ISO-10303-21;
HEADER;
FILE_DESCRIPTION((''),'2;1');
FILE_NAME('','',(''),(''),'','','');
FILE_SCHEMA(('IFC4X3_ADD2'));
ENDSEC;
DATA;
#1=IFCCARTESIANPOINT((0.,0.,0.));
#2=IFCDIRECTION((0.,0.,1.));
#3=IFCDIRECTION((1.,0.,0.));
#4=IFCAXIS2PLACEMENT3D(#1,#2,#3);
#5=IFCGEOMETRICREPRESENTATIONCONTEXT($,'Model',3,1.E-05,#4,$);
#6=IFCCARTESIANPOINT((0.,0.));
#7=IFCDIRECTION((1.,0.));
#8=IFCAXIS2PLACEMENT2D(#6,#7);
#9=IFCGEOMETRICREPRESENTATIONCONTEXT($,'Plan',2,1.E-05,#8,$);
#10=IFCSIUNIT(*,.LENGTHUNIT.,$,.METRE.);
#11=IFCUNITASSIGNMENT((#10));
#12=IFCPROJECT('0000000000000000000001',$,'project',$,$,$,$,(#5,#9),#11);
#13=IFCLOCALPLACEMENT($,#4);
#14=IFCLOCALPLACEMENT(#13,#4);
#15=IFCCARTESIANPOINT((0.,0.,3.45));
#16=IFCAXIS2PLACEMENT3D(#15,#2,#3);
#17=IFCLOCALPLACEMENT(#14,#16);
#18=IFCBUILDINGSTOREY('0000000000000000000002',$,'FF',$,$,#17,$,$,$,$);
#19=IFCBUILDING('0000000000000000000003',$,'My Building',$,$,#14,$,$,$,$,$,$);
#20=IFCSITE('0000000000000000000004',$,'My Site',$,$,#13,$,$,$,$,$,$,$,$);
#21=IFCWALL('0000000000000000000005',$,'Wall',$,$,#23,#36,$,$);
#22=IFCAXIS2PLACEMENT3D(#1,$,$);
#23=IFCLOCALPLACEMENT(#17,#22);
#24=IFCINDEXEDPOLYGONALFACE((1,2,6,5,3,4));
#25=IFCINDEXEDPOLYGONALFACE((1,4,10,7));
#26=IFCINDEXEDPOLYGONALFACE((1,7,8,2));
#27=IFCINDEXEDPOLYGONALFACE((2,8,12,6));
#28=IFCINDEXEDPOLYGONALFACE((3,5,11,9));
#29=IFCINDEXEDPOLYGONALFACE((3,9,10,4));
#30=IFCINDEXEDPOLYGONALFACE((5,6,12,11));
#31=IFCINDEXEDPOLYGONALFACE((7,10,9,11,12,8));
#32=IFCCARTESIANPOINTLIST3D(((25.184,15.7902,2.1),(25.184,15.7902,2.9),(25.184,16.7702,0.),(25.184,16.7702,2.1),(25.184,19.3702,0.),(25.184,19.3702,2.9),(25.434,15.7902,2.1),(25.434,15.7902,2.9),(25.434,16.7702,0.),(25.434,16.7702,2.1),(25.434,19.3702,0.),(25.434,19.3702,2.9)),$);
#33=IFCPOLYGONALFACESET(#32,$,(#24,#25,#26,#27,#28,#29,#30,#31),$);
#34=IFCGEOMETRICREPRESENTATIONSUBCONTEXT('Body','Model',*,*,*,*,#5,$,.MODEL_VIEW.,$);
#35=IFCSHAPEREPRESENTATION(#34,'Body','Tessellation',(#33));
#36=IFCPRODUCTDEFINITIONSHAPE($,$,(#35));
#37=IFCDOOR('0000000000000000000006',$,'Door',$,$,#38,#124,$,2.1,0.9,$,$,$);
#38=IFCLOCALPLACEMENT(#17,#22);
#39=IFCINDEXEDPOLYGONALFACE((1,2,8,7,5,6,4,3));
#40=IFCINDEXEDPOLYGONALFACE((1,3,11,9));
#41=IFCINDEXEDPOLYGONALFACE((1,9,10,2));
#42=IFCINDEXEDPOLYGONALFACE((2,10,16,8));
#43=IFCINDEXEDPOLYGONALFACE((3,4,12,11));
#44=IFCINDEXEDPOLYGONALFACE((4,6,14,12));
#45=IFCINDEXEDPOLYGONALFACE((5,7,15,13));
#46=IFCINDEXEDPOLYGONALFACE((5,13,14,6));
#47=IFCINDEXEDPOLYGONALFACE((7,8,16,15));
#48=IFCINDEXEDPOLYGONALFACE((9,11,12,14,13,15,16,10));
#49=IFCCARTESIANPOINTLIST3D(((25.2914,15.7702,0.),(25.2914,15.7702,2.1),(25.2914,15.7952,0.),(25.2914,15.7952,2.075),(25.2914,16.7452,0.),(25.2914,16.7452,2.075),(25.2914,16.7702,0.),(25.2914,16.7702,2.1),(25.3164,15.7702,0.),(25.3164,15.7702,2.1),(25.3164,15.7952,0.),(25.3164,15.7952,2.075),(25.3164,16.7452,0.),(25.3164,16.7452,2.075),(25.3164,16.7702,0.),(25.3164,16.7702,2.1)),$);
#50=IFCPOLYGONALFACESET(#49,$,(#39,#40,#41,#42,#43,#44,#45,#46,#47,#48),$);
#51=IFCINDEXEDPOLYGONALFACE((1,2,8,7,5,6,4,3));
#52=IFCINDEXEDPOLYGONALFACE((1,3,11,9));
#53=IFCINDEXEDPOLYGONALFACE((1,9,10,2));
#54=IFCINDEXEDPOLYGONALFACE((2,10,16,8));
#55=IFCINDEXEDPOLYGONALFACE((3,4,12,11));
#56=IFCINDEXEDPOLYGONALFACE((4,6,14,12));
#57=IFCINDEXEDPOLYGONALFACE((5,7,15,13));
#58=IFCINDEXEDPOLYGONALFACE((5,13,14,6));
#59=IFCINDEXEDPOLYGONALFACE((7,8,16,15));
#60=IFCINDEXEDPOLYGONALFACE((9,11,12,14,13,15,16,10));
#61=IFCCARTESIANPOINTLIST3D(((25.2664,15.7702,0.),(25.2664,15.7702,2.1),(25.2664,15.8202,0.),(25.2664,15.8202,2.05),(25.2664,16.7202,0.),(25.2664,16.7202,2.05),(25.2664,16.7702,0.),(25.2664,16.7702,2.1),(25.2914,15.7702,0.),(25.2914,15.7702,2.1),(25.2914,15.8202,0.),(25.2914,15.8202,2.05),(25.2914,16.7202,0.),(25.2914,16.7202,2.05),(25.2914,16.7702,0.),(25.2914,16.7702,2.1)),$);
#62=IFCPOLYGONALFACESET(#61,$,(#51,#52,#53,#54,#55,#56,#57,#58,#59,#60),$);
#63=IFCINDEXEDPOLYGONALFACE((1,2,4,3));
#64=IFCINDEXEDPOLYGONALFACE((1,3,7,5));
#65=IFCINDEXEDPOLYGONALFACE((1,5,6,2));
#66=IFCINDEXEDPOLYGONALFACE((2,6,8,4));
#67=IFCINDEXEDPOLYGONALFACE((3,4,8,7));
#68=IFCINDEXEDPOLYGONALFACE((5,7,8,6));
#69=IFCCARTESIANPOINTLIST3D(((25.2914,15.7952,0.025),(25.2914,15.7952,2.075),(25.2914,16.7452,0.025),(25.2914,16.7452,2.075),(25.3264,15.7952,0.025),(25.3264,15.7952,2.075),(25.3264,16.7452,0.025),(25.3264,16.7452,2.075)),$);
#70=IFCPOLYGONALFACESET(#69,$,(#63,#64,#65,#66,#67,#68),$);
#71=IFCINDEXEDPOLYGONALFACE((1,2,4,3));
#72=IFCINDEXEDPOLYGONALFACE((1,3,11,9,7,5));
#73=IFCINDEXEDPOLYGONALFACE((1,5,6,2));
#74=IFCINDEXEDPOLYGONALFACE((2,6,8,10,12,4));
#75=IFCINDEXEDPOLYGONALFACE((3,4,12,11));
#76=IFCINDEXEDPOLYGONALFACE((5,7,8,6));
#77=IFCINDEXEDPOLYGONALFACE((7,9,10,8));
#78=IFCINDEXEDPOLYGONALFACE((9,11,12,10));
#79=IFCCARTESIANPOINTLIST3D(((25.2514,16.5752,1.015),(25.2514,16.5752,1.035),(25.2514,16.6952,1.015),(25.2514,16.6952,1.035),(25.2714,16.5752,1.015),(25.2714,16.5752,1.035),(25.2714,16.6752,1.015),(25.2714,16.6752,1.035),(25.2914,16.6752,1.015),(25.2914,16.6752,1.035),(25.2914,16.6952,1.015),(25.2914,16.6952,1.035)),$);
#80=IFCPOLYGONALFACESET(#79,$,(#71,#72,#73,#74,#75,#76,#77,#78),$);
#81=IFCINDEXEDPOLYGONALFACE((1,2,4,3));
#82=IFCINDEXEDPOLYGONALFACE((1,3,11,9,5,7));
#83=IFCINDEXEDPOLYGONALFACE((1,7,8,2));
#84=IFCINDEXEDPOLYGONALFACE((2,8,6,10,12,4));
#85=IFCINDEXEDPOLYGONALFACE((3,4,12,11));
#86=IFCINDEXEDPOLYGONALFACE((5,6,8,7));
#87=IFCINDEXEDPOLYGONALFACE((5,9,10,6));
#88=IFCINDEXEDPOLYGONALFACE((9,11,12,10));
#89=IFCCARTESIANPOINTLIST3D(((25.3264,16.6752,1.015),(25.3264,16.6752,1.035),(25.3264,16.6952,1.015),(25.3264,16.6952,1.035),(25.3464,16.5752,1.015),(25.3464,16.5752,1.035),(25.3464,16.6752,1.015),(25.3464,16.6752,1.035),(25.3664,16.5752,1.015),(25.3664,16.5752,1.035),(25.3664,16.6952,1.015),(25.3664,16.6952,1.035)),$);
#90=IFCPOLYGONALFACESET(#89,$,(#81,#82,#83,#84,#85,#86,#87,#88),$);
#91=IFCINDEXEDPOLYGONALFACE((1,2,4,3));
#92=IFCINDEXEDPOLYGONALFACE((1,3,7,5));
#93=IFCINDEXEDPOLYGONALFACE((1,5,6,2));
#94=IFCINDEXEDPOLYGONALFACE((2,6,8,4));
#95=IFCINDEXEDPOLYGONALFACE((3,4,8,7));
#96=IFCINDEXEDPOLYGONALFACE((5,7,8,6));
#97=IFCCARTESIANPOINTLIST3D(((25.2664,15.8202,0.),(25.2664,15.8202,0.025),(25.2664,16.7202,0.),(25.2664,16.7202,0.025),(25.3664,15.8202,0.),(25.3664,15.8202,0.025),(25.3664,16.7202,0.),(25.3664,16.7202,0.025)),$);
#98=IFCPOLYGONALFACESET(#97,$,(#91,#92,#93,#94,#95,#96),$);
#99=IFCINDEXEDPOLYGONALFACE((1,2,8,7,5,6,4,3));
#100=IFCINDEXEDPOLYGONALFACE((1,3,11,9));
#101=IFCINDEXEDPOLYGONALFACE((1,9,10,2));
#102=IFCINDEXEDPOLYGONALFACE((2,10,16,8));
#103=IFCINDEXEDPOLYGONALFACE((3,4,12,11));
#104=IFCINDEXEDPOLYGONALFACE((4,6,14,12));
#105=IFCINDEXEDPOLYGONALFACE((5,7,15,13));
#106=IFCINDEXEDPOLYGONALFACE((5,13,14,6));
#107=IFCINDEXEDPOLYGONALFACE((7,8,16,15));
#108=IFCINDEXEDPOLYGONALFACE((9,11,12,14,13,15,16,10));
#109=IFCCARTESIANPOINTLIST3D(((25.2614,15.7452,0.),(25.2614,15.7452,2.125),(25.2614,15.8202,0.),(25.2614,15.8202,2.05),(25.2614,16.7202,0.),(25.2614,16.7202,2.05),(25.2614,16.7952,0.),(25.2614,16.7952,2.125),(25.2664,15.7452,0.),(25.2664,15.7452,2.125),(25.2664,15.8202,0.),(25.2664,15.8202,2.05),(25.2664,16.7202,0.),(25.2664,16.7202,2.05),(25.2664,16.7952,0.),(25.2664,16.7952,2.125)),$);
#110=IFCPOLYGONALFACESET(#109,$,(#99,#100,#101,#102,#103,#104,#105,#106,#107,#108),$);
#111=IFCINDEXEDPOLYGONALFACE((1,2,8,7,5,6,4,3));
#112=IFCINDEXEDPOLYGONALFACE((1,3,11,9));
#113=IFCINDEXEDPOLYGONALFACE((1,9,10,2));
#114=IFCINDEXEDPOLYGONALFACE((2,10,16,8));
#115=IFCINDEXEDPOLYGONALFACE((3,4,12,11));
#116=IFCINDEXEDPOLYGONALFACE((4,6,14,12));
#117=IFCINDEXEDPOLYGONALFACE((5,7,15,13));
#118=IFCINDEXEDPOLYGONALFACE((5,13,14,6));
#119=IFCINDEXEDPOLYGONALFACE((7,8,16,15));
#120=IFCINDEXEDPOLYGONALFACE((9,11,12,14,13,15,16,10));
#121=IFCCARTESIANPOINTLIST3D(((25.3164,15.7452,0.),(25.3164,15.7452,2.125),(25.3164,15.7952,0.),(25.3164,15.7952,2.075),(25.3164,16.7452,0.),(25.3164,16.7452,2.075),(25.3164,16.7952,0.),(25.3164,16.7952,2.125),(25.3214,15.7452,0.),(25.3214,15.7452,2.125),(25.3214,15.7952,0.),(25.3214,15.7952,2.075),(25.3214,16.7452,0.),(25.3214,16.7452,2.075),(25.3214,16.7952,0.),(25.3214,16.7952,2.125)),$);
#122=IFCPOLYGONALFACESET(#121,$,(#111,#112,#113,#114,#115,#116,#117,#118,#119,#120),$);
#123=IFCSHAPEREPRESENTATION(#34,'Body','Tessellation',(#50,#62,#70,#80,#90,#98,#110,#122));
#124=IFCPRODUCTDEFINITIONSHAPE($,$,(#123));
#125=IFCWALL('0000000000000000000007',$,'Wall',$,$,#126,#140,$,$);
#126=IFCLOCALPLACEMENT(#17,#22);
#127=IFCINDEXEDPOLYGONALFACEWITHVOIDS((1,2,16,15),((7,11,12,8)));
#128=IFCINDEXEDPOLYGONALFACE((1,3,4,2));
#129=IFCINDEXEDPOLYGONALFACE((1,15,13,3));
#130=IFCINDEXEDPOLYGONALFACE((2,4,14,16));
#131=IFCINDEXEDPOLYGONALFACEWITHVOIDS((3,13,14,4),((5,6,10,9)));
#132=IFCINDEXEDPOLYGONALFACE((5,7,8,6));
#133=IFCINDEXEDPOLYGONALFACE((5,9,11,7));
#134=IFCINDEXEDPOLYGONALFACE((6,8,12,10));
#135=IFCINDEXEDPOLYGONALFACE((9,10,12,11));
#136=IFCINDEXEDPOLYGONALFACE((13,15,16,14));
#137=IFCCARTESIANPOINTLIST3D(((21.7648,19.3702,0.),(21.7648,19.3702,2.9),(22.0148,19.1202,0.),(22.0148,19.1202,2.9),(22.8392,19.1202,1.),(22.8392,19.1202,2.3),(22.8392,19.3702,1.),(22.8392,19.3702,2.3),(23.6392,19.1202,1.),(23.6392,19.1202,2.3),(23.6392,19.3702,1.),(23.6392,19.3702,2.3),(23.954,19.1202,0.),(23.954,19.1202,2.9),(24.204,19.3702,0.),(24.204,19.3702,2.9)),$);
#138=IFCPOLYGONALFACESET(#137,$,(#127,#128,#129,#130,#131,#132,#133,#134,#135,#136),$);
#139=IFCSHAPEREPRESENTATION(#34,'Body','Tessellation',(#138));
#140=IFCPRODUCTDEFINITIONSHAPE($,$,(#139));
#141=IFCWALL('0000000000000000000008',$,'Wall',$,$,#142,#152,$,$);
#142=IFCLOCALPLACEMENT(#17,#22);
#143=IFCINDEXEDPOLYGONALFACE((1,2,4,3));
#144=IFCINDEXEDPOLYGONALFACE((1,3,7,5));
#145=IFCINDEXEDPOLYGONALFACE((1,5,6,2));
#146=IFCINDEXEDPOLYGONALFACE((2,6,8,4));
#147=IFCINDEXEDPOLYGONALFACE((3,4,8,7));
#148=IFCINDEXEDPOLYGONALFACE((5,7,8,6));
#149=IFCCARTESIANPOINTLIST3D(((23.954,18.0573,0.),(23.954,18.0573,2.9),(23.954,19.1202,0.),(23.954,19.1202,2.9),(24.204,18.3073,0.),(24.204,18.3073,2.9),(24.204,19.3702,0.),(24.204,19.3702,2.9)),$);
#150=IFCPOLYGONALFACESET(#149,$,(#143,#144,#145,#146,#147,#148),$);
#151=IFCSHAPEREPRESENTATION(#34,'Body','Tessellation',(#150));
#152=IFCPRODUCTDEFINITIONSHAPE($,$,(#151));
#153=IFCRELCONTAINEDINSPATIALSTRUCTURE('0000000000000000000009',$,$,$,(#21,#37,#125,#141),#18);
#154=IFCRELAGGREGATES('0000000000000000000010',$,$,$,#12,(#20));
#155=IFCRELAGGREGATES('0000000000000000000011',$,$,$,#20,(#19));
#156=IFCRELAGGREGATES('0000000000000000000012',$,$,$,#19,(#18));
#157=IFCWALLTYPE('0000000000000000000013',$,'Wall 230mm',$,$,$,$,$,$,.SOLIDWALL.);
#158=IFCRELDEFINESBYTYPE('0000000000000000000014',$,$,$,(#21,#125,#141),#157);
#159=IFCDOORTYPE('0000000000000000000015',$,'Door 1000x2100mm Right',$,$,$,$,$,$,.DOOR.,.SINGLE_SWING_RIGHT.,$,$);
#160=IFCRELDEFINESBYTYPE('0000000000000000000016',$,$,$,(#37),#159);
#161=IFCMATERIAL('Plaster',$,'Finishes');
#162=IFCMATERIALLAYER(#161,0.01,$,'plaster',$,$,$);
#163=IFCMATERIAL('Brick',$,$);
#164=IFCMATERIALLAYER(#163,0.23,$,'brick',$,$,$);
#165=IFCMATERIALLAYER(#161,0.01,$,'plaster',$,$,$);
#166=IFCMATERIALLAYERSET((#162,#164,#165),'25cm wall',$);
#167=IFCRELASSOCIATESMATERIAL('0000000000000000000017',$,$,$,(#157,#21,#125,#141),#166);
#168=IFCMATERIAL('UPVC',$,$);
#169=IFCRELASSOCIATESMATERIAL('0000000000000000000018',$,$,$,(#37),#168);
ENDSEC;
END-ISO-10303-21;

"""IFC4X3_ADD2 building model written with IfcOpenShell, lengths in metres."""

from ifc_helpers import new_model, entity, si_unit, frame, origin_with_axes, origin_2d_with_axis, place, context, subcontext, project, spatial, line, indexed_curve, outline, extrude, shape, source, transform, mapped, material, layer, layer_set, layer_usage, type_object, type_shapes, element, fill, save


model = new_model("IFC4X3_ADD2")

# Units and contexts
model_context = context("Model", 3, precision=1e-05, world=origin_with_axes())
plan_context = context("Plan", 2, precision=1e-05, world=origin_2d_with_axis())
body_context_1 = subcontext(model_context, "Body", "Model", "MODEL_VIEW")
body_context_2 = subcontext(plan_context, "Body", "Plan", "PLAN_VIEW")
ifc_project = project(units=[si_unit("LENGTHUNIT", "METRE")], contexts=[model_context, plan_context])

# Site, building, storey
site_placement = place(None, origin_with_axes())
site = spatial("IfcSite", under=ifc_project, at=site_placement, Name="My Site")
building_placement = place(site_placement, origin_with_axes())
building = spatial("IfcBuilding", under=site, at=building_placement, Name="My Building")
storey_placement = place(building_placement, frame((0.0, 0.0, 3.45), z_axis=(0.0, 0.0, 1.0), x_axis=(1.0, 0.0, 0.0)))
storey = spatial("IfcBuildingStorey", under=building, at=storey_placement, Name="FF")

# Shared definitions
ifc_material_1 = material(Name="UPVC")

# Shared definitions
ifc_material_2 = material(Name="Plaster", Category="Finishes")
ifc_layer_1 = layer(ifc_material_2, 0.01, Name="plaster")
ifc_material_3 = material(Name="Brick")
ifc_layer_2 = layer(ifc_material_3, 0.23, Name="brick")
ifc_layer_3 = layer(ifc_material_2, 0.01, Name="plaster")
ifc_layer_set = layer_set([ifc_layer_1, ifc_layer_2, ifc_layer_3], Name="25cm wall")
wall_type = type_object("IfcWallType", Name="Wall 230mm", PredefinedType="SOLIDWALL", material=ifc_layer_set)
shared_shape_1 = source(origin_with_axes(), body_context_1, "Body", "SweptSolid", [
    extrude(outline(indexed_curve([(0.0, 0.0), (0.8, 0.0), (0.8, 1.3), (0.0, 1.3)], segments=[line(1, 2, 3, 4, 1)])), frame((-0.4, -0.6, 0.0), z_axis=(0.0, -1.0, 0.0), x_axis=(1.0, 0.0, 0.0)), (0.0, 0.0, -1.0), 1.2),
])

# Wall, opening, door
ifc_layer_usage_1 = layer_usage(ifc_layer_set, "AXIS2", "POSITIVE", 0.0)
wall_1_placement = place(storey_placement, frame((25.434, 15.5402, 0.0), z_axis=(0.0, 0.0, 1.0), x_axis=(0.000001, 1.0, 0.0)))
wall_1 = element("IfcWall", 1, at=wall_1_placement, inside=storey, type_object=wall_type, material=ifc_layer_usage_1, Name="Wall", context=body_context_1, shape_type="SweptSolid", body=[
    extrude(outline(indexed_curve([(0.25, 0.0), (0.25, 0.25), (3.83, 0.25), (3.83, 0.0)], segments=[line(1, 2, 3, 4, 1)])), origin_with_axes(), (0.0, 0.0, 1.0), 2.9),
])
shared_shape_2 = source(origin_with_axes(), body_context_1, "Body", "SweptSolid", [
    extrude(outline(indexed_curve([(0.0, 0.0), (1.0, 0.0), (1.0, 2.1), (0.0, 2.1)], segments=[line(1, 2, 3, 4, 1)])), frame((0.0, -0.6, 0.0), z_axis=(0.0, -1.0, 0.0), x_axis=(1.0, 0.0, 0.0)), (0.0, 0.0, -1.0), 1.2),
])
opening_1_placement = place(wall_1_placement, frame((1.23, 0.1676, 0.0), z_axis=(0.0, 0.0, 1.0), x_axis=(-1.0, 0.0, 0.0)))
opening_1 = element("IfcOpeningElement", 2, at=opening_1_placement, cuts=wall_1, PredefinedType="OPENING", context=body_context_1, shape_type="MappedRepresentation", body=[
    mapped(shared_shape_2, transform((0.0, 0.0, 0.0), x_axis=(1.0, 0.0, 0.0), y_axis=(0.0, 1.0, 0.0), z_axis=(0.0, 0.0, 1.0), scale=1.0)),
])
door_type_1 = type_object("IfcDoorType", Name="Door 1000x2100mm Right", OperationType="SINGLE_SWING_RIGHT", PredefinedType="DOOR")
shared_shape_3 = source(origin_with_axes(), body_context_1, "Body", "SweptSolid", [
    extrude(outline(indexed_curve([(0.0, 0.0), (0.0, 2.1), (1.0, 2.1), (1.0, 0.0), (0.975, 0.0), (0.975, 2.075), (0.025, 2.075), (0.025, 0.0)], segments=[line(1, 2, 3, 4, 5, 6, 7, 8, 1)])), frame((0.0, 0.025, 0.0), z_axis=(0.0, -1.0, 0.0), x_axis=(1.0, 0.0, 0.0)), (0.0, 0.0, -1.0), 0.025),
    extrude(outline(indexed_curve([(0.0, 0.0), (0.0, 2.1), (1.0, 2.1), (1.0, 0.0), (0.95, 0.0), (0.95, 2.05), (0.05, 2.05), (0.05, 0.0)], segments=[line(1, 2, 3, 4, 5, 6, 7, 8, 1)])), frame((0.0, 0.0, 0.0), z_axis=(0.0, -1.0, 0.0), x_axis=(1.0, 0.0, 0.0)), (0.0, 0.0, -1.0), 0.025),
    extrude(outline(indexed_curve([(0.0, 0.0), (0.95, 0.0), (0.95, 0.035), (0.0, 0.035)], segments=[line(1, 2, 3, 4, 1)])), frame((0.025, 0.025, 0.025), z_axis=(0.0, 0.0, 1.0), x_axis=(1.0, 0.0, 0.0)), (0.0, 0.0, 1.0), 2.05),
    extrude(outline(indexed_curve([(0.0, 0.0), (0.0, -0.04), (0.12, -0.04), (0.12, -0.02), (0.02, -0.02), (0.02, 0.0)], segments=[line(1, 2, 3, 4, 5, 6, 1)])), frame((0.075, 0.025, 1.015), z_axis=(0.0, 0.0, 1.0), x_axis=(1.0, 0.0, 0.0)), (0.0, 0.0, 1.0), 0.02),
    extrude(outline(indexed_curve([(0.0, 0.0), (0.0, 0.04), (0.12, 0.04), (0.12, 0.02), (0.02, 0.02), (0.02, 0.0)], segments=[line(1, 2, 3, 4, 5, 6, 1)])), frame((0.075, 0.06, 1.015), z_axis=(0.0, 0.0, 1.0), x_axis=(1.0, 0.0, 0.0)), (0.0, 0.0, 1.0), 0.02),
    extrude(outline(indexed_curve([(0.0, 0.0), (0.9, 0.0), (0.9, 0.1), (0.0, 0.1)], segments=[line(1, 2, 3, 4, 1)])), frame((0.05, 0.0, 0.0), z_axis=(0.0, 0.0, 1.0), x_axis=(1.0, 0.0, 0.0)), (0.0, 0.0, 1.0), 0.025),
    extrude(outline(indexed_curve([(0.0, 0.0), (0.0, 2.125), (1.05, 2.125), (1.05, 0.0), (0.975, 0.0), (0.975, 2.05), (0.075, 2.05), (0.075, 0.0)], segments=[line(1, 2, 3, 4, 5, 6, 7, 8, 1)])), frame((-0.025, -0.005, 0.0), z_axis=(0.0, -1.0, 0.0), x_axis=(1.0, 0.0, 0.0)), (0.0, 0.0, -1.0), 0.005),
    extrude(outline(indexed_curve([(0.0, 0.0), (0.0, 2.125), (1.05, 2.125), (1.05, 0.0), (1.0, 0.0), (1.0, 2.075), (0.05, 2.075), (0.05, 0.0)], segments=[line(1, 2, 3, 4, 5, 6, 7, 8, 1)])), frame((-0.025, 0.05, 0.0), z_axis=(0.0, -1.0, 0.0), x_axis=(1.0, 0.0, 0.0)), (0.0, 0.0, -1.0), 0.005),
])
shared_shape_4 = source(origin_with_axes(), body_context_2, "Body", "Curve2D", [
    entity("IfcIndexedPolyCurve", entity("IfcCartesianPointList2D", [[0.0, 0.0], [0.0, 0.05], [0.025, 0.05], [0.025, 0.025], [0.05, 0.025], [0.05, 0.0]]), [entity("IfcLineIndex", [1, 2, 3, 4, 5, 6, 1])]),
    entity("IfcIndexedPolyCurve", entity("IfcCartesianPointList2D", [[1.0, 0.0], [1.0, 0.05], [0.975, 0.05], [0.975, 0.025], [0.95, 0.025], [0.95, 0.0]]), [entity("IfcLineIndex", [1, 2, 3, 4, 5, 6, 1])]),
    entity("IfcTrimmedCurve", entity("IfcEllipse", entity("IfcAxis2Placement2D", entity("IfcCartesianPoint", [0.94, 0.05]), entity("IfcDirection", [1.0, 0.0])), 0.915, 0.95), [entity("IfcCartesianPoint", [0.94, 1.0])], [entity("IfcCartesianPoint", [0.025, 0.05])], True, "CARTESIAN"),
    entity("IfcIndexedPolyCurve", entity("IfcCartesianPointList2D", [[0.975, 0.05], [0.94, 0.05], [0.94, 1.0], [0.975, 1.0]]), [entity("IfcLineIndex", [1, 2, 3, 4, 1])]),
])
type_shapes(door_type_1, [shared_shape_3, shared_shape_4])
door_1_placement = place(opening_1_placement, origin_with_axes())
door_1 = element("IfcDoor", 3, at=door_1_placement, inside=storey, type_object=door_type_1, material=ifc_material_1, Name="Door", OverallHeight=2.1, OverallWidth=0.9, shapes=[
    shape(body_context_1, "Body", "MappedRepresentation", [mapped(shared_shape_3, transform((0.0, 0.0, 0.0), x_axis=(1.0, 0.0, 0.0), y_axis=(0.0, 1.0, 0.0), z_axis=(0.0, 0.0, 1.0), scale=1.0))]),
    shape(body_context_2, "Body", "MappedRepresentation", [mapped(shared_shape_4, transform((0.0, 0.0, 0.0), x_axis=(1.0, 0.0, 0.0), y_axis=(0.0, 1.0, 0.0), z_axis=(0.0, 0.0, 1.0), scale=1.0))]),
])
fill(opening_1, door_1)

# Wall, opening
ifc_layer_usage_2 = layer_usage(ifc_layer_set, "AXIS2", "POSITIVE", 0.0)
wall_2_placement = place(storey_placement, frame((24.204, 19.3702, 0.0), z_axis=(0.0, 0.0, 1.0), x_axis=(-1.0, 0.0, 0.0)))
wall_2 = element("IfcWall", 4, at=wall_2_placement, inside=storey, type_object=wall_type, material=ifc_layer_usage_2, Name="Wall", context=body_context_1, shape_type="SweptSolid", body=[
    extrude(outline(indexed_curve([(0.0, 0.0), (0.25, 0.25), (2.1892, 0.25), (2.4392, 0.0)], segments=[line(1, 2, 3, 4, 1)])), origin_with_axes(), (0.0, 0.0, 1.0), 2.9),
])
opening_2_placement = place(wall_2_placement, frame((0.9648, 0.0, 1.0), z_axis=(0.0, 0.0, 1.0), x_axis=(1.0, 0.0, 0.0)))
element("IfcOpeningElement", 5, at=opening_2_placement, cuts=wall_2, PredefinedType="OPENING", context=body_context_1, shape_type="MappedRepresentation", body=[
    mapped(shared_shape_1, transform((0.0, 0.0, 0.0), x_axis=(1.0, 0.0, 0.0), y_axis=(0.0, 1.0, 0.0), z_axis=(0.0, 0.0, 1.0), scale=1.0)),
])

# Wall
ifc_layer_usage_3 = layer_usage(ifc_layer_set, "AXIS2", "POSITIVE", 0.0)
wall_3_placement = place(storey_placement, frame((24.204, 18.3073, 0.0), z_axis=(0.0, 0.0, 1.0), x_axis=(0.000001, 1.0, 0.0)))
element("IfcWall", 6, at=wall_3_placement, inside=storey, type_object=wall_type, material=ifc_layer_usage_3, Name="Wall", context=body_context_1, shape_type="SweptSolid", body=[
    extrude(outline(indexed_curve([(0.0, 0.0), (-0.25, 0.25), (0.8129, 0.25), (1.0629, 0.0)], segments=[line(1, 2, 3, 4, 1)])), origin_with_axes(), (0.0, 0.0, 1.0), 2.9),
])

save(model, "model.ifc")
